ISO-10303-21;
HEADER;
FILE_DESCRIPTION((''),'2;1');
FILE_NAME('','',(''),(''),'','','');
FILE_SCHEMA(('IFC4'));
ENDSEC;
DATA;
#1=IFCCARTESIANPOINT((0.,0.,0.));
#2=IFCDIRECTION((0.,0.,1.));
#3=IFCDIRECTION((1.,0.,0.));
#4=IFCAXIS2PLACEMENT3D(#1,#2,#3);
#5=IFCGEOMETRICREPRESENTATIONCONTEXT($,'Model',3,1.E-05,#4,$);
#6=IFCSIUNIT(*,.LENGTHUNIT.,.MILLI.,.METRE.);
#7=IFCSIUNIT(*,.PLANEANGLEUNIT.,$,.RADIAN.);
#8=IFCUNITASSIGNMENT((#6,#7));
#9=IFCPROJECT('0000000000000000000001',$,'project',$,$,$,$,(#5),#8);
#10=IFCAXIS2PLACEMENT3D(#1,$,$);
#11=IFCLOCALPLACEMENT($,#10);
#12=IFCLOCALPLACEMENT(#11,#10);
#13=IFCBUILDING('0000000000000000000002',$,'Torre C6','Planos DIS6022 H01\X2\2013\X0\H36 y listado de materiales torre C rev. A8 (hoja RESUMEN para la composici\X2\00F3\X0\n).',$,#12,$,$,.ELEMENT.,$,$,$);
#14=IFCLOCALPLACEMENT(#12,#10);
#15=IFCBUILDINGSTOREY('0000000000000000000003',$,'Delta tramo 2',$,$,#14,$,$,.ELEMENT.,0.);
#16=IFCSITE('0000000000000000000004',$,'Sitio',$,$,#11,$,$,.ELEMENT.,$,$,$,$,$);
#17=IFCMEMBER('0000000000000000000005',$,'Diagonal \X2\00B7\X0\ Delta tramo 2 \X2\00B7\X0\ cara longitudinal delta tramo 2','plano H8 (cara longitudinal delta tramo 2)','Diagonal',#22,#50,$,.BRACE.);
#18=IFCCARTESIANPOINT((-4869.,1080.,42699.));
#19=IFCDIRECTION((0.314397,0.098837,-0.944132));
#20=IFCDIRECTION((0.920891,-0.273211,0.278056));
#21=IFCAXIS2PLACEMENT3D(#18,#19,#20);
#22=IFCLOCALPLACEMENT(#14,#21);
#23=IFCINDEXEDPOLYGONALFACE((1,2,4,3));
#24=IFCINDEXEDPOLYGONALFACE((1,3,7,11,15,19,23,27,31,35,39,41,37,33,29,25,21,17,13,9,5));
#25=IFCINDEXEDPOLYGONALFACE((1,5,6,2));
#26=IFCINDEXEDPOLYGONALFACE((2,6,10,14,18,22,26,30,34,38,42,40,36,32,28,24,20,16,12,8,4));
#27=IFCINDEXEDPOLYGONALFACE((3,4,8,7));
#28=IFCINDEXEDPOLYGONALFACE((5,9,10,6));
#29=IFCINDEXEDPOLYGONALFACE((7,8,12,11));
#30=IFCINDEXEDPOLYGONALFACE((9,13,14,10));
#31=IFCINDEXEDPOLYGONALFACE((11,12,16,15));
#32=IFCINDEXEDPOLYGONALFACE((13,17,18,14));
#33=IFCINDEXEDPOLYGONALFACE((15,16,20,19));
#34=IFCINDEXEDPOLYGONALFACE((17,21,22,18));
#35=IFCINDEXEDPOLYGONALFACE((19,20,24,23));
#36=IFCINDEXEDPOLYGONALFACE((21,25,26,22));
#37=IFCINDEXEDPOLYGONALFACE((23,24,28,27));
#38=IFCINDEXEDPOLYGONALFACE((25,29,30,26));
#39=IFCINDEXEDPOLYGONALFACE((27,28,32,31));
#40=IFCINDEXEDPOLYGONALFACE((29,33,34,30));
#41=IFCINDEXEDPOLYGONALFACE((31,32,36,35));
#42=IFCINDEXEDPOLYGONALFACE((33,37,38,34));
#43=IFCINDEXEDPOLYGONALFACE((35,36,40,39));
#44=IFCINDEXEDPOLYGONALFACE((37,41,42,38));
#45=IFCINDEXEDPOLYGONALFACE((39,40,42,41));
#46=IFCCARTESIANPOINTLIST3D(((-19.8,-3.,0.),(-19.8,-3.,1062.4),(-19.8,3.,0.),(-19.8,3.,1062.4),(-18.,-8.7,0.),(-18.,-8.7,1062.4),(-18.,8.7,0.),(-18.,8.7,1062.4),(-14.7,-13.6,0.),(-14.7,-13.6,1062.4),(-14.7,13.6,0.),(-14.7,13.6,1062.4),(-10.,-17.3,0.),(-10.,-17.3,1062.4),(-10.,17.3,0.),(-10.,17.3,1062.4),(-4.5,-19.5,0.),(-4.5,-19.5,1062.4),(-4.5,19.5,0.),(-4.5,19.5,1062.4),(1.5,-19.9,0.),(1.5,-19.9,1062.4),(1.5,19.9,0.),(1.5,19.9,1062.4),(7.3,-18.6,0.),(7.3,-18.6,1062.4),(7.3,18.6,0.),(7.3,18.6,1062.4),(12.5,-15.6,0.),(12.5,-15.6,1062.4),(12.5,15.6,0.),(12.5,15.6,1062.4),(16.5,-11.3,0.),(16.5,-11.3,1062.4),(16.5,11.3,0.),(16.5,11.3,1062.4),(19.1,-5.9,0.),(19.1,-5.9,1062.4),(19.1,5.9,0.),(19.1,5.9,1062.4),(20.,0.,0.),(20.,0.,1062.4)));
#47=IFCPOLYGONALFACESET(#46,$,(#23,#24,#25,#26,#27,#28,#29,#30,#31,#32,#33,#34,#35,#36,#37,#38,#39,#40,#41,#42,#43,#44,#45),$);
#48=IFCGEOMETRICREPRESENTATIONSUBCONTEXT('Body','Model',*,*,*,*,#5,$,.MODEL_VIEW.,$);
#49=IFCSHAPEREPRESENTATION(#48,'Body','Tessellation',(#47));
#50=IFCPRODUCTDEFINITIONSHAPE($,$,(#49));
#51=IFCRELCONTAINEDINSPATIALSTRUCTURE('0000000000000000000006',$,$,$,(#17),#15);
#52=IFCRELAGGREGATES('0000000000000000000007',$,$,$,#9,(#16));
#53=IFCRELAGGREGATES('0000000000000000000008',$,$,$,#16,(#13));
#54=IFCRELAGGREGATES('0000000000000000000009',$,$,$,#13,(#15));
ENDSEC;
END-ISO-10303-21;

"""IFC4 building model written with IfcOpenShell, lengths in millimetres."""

from ifc_helpers import new_model, si_unit, frame, origin, origin_with_axes, place, context, subcontext, project, spatial, circle, extrude, element, save


model = new_model("IFC4")

# Units and contexts
model_context = context("Model", 3, precision=1e-05, world=origin_with_axes())
body_context = subcontext(model_context, "Body", "Model", "MODEL_VIEW")
ifc_project = project(units=[si_unit("LENGTHUNIT", "METRE", prefix="MILLI"), si_unit("PLANEANGLEUNIT", "RADIAN")], contexts=[model_context])

# Site, building, storey
site_placement = place(None, origin())
site = spatial("IfcSite", under=ifc_project, at=site_placement, Name="Sitio", CompositionType="ELEMENT")
building_placement = place(site_placement, origin())
building = spatial("IfcBuilding", under=site, at=building_placement, Name="Torre C6", Description="Planos DIS6022 H01–H36 y listado de materiales torre C rev. A8 (hoja RESUMEN para la composición).", CompositionType="ELEMENT")
storey_placement = place(building_placement, origin())
storey = spatial("IfcBuildingStorey", under=building, at=storey_placement, Name="Delta tramo 2", CompositionType="ELEMENT", Elevation=0.0)

# Member
member_1_placement = place(storey_placement, frame((-4869.0, 1080.0, 42699.0), z_axis=(0.314397, 0.098837, -0.944132), x_axis=(0.920891, -0.273211, 0.278056)))
element("IfcMember", 1, at=member_1_placement, inside=storey, Name="Diagonal · Delta tramo 2 · cara longitudinal delta tramo 2", Description="plano H8 (cara longitudinal delta tramo 2)", ObjectType="Diagonal", PredefinedType="BRACE", context=body_context, shape_type="SweptSolid", body=[
    extrude(circle(Radius=20.0), None, (0.0, 0.0, 1.0), 1062.4),
])

save(model, "model.ifc")
